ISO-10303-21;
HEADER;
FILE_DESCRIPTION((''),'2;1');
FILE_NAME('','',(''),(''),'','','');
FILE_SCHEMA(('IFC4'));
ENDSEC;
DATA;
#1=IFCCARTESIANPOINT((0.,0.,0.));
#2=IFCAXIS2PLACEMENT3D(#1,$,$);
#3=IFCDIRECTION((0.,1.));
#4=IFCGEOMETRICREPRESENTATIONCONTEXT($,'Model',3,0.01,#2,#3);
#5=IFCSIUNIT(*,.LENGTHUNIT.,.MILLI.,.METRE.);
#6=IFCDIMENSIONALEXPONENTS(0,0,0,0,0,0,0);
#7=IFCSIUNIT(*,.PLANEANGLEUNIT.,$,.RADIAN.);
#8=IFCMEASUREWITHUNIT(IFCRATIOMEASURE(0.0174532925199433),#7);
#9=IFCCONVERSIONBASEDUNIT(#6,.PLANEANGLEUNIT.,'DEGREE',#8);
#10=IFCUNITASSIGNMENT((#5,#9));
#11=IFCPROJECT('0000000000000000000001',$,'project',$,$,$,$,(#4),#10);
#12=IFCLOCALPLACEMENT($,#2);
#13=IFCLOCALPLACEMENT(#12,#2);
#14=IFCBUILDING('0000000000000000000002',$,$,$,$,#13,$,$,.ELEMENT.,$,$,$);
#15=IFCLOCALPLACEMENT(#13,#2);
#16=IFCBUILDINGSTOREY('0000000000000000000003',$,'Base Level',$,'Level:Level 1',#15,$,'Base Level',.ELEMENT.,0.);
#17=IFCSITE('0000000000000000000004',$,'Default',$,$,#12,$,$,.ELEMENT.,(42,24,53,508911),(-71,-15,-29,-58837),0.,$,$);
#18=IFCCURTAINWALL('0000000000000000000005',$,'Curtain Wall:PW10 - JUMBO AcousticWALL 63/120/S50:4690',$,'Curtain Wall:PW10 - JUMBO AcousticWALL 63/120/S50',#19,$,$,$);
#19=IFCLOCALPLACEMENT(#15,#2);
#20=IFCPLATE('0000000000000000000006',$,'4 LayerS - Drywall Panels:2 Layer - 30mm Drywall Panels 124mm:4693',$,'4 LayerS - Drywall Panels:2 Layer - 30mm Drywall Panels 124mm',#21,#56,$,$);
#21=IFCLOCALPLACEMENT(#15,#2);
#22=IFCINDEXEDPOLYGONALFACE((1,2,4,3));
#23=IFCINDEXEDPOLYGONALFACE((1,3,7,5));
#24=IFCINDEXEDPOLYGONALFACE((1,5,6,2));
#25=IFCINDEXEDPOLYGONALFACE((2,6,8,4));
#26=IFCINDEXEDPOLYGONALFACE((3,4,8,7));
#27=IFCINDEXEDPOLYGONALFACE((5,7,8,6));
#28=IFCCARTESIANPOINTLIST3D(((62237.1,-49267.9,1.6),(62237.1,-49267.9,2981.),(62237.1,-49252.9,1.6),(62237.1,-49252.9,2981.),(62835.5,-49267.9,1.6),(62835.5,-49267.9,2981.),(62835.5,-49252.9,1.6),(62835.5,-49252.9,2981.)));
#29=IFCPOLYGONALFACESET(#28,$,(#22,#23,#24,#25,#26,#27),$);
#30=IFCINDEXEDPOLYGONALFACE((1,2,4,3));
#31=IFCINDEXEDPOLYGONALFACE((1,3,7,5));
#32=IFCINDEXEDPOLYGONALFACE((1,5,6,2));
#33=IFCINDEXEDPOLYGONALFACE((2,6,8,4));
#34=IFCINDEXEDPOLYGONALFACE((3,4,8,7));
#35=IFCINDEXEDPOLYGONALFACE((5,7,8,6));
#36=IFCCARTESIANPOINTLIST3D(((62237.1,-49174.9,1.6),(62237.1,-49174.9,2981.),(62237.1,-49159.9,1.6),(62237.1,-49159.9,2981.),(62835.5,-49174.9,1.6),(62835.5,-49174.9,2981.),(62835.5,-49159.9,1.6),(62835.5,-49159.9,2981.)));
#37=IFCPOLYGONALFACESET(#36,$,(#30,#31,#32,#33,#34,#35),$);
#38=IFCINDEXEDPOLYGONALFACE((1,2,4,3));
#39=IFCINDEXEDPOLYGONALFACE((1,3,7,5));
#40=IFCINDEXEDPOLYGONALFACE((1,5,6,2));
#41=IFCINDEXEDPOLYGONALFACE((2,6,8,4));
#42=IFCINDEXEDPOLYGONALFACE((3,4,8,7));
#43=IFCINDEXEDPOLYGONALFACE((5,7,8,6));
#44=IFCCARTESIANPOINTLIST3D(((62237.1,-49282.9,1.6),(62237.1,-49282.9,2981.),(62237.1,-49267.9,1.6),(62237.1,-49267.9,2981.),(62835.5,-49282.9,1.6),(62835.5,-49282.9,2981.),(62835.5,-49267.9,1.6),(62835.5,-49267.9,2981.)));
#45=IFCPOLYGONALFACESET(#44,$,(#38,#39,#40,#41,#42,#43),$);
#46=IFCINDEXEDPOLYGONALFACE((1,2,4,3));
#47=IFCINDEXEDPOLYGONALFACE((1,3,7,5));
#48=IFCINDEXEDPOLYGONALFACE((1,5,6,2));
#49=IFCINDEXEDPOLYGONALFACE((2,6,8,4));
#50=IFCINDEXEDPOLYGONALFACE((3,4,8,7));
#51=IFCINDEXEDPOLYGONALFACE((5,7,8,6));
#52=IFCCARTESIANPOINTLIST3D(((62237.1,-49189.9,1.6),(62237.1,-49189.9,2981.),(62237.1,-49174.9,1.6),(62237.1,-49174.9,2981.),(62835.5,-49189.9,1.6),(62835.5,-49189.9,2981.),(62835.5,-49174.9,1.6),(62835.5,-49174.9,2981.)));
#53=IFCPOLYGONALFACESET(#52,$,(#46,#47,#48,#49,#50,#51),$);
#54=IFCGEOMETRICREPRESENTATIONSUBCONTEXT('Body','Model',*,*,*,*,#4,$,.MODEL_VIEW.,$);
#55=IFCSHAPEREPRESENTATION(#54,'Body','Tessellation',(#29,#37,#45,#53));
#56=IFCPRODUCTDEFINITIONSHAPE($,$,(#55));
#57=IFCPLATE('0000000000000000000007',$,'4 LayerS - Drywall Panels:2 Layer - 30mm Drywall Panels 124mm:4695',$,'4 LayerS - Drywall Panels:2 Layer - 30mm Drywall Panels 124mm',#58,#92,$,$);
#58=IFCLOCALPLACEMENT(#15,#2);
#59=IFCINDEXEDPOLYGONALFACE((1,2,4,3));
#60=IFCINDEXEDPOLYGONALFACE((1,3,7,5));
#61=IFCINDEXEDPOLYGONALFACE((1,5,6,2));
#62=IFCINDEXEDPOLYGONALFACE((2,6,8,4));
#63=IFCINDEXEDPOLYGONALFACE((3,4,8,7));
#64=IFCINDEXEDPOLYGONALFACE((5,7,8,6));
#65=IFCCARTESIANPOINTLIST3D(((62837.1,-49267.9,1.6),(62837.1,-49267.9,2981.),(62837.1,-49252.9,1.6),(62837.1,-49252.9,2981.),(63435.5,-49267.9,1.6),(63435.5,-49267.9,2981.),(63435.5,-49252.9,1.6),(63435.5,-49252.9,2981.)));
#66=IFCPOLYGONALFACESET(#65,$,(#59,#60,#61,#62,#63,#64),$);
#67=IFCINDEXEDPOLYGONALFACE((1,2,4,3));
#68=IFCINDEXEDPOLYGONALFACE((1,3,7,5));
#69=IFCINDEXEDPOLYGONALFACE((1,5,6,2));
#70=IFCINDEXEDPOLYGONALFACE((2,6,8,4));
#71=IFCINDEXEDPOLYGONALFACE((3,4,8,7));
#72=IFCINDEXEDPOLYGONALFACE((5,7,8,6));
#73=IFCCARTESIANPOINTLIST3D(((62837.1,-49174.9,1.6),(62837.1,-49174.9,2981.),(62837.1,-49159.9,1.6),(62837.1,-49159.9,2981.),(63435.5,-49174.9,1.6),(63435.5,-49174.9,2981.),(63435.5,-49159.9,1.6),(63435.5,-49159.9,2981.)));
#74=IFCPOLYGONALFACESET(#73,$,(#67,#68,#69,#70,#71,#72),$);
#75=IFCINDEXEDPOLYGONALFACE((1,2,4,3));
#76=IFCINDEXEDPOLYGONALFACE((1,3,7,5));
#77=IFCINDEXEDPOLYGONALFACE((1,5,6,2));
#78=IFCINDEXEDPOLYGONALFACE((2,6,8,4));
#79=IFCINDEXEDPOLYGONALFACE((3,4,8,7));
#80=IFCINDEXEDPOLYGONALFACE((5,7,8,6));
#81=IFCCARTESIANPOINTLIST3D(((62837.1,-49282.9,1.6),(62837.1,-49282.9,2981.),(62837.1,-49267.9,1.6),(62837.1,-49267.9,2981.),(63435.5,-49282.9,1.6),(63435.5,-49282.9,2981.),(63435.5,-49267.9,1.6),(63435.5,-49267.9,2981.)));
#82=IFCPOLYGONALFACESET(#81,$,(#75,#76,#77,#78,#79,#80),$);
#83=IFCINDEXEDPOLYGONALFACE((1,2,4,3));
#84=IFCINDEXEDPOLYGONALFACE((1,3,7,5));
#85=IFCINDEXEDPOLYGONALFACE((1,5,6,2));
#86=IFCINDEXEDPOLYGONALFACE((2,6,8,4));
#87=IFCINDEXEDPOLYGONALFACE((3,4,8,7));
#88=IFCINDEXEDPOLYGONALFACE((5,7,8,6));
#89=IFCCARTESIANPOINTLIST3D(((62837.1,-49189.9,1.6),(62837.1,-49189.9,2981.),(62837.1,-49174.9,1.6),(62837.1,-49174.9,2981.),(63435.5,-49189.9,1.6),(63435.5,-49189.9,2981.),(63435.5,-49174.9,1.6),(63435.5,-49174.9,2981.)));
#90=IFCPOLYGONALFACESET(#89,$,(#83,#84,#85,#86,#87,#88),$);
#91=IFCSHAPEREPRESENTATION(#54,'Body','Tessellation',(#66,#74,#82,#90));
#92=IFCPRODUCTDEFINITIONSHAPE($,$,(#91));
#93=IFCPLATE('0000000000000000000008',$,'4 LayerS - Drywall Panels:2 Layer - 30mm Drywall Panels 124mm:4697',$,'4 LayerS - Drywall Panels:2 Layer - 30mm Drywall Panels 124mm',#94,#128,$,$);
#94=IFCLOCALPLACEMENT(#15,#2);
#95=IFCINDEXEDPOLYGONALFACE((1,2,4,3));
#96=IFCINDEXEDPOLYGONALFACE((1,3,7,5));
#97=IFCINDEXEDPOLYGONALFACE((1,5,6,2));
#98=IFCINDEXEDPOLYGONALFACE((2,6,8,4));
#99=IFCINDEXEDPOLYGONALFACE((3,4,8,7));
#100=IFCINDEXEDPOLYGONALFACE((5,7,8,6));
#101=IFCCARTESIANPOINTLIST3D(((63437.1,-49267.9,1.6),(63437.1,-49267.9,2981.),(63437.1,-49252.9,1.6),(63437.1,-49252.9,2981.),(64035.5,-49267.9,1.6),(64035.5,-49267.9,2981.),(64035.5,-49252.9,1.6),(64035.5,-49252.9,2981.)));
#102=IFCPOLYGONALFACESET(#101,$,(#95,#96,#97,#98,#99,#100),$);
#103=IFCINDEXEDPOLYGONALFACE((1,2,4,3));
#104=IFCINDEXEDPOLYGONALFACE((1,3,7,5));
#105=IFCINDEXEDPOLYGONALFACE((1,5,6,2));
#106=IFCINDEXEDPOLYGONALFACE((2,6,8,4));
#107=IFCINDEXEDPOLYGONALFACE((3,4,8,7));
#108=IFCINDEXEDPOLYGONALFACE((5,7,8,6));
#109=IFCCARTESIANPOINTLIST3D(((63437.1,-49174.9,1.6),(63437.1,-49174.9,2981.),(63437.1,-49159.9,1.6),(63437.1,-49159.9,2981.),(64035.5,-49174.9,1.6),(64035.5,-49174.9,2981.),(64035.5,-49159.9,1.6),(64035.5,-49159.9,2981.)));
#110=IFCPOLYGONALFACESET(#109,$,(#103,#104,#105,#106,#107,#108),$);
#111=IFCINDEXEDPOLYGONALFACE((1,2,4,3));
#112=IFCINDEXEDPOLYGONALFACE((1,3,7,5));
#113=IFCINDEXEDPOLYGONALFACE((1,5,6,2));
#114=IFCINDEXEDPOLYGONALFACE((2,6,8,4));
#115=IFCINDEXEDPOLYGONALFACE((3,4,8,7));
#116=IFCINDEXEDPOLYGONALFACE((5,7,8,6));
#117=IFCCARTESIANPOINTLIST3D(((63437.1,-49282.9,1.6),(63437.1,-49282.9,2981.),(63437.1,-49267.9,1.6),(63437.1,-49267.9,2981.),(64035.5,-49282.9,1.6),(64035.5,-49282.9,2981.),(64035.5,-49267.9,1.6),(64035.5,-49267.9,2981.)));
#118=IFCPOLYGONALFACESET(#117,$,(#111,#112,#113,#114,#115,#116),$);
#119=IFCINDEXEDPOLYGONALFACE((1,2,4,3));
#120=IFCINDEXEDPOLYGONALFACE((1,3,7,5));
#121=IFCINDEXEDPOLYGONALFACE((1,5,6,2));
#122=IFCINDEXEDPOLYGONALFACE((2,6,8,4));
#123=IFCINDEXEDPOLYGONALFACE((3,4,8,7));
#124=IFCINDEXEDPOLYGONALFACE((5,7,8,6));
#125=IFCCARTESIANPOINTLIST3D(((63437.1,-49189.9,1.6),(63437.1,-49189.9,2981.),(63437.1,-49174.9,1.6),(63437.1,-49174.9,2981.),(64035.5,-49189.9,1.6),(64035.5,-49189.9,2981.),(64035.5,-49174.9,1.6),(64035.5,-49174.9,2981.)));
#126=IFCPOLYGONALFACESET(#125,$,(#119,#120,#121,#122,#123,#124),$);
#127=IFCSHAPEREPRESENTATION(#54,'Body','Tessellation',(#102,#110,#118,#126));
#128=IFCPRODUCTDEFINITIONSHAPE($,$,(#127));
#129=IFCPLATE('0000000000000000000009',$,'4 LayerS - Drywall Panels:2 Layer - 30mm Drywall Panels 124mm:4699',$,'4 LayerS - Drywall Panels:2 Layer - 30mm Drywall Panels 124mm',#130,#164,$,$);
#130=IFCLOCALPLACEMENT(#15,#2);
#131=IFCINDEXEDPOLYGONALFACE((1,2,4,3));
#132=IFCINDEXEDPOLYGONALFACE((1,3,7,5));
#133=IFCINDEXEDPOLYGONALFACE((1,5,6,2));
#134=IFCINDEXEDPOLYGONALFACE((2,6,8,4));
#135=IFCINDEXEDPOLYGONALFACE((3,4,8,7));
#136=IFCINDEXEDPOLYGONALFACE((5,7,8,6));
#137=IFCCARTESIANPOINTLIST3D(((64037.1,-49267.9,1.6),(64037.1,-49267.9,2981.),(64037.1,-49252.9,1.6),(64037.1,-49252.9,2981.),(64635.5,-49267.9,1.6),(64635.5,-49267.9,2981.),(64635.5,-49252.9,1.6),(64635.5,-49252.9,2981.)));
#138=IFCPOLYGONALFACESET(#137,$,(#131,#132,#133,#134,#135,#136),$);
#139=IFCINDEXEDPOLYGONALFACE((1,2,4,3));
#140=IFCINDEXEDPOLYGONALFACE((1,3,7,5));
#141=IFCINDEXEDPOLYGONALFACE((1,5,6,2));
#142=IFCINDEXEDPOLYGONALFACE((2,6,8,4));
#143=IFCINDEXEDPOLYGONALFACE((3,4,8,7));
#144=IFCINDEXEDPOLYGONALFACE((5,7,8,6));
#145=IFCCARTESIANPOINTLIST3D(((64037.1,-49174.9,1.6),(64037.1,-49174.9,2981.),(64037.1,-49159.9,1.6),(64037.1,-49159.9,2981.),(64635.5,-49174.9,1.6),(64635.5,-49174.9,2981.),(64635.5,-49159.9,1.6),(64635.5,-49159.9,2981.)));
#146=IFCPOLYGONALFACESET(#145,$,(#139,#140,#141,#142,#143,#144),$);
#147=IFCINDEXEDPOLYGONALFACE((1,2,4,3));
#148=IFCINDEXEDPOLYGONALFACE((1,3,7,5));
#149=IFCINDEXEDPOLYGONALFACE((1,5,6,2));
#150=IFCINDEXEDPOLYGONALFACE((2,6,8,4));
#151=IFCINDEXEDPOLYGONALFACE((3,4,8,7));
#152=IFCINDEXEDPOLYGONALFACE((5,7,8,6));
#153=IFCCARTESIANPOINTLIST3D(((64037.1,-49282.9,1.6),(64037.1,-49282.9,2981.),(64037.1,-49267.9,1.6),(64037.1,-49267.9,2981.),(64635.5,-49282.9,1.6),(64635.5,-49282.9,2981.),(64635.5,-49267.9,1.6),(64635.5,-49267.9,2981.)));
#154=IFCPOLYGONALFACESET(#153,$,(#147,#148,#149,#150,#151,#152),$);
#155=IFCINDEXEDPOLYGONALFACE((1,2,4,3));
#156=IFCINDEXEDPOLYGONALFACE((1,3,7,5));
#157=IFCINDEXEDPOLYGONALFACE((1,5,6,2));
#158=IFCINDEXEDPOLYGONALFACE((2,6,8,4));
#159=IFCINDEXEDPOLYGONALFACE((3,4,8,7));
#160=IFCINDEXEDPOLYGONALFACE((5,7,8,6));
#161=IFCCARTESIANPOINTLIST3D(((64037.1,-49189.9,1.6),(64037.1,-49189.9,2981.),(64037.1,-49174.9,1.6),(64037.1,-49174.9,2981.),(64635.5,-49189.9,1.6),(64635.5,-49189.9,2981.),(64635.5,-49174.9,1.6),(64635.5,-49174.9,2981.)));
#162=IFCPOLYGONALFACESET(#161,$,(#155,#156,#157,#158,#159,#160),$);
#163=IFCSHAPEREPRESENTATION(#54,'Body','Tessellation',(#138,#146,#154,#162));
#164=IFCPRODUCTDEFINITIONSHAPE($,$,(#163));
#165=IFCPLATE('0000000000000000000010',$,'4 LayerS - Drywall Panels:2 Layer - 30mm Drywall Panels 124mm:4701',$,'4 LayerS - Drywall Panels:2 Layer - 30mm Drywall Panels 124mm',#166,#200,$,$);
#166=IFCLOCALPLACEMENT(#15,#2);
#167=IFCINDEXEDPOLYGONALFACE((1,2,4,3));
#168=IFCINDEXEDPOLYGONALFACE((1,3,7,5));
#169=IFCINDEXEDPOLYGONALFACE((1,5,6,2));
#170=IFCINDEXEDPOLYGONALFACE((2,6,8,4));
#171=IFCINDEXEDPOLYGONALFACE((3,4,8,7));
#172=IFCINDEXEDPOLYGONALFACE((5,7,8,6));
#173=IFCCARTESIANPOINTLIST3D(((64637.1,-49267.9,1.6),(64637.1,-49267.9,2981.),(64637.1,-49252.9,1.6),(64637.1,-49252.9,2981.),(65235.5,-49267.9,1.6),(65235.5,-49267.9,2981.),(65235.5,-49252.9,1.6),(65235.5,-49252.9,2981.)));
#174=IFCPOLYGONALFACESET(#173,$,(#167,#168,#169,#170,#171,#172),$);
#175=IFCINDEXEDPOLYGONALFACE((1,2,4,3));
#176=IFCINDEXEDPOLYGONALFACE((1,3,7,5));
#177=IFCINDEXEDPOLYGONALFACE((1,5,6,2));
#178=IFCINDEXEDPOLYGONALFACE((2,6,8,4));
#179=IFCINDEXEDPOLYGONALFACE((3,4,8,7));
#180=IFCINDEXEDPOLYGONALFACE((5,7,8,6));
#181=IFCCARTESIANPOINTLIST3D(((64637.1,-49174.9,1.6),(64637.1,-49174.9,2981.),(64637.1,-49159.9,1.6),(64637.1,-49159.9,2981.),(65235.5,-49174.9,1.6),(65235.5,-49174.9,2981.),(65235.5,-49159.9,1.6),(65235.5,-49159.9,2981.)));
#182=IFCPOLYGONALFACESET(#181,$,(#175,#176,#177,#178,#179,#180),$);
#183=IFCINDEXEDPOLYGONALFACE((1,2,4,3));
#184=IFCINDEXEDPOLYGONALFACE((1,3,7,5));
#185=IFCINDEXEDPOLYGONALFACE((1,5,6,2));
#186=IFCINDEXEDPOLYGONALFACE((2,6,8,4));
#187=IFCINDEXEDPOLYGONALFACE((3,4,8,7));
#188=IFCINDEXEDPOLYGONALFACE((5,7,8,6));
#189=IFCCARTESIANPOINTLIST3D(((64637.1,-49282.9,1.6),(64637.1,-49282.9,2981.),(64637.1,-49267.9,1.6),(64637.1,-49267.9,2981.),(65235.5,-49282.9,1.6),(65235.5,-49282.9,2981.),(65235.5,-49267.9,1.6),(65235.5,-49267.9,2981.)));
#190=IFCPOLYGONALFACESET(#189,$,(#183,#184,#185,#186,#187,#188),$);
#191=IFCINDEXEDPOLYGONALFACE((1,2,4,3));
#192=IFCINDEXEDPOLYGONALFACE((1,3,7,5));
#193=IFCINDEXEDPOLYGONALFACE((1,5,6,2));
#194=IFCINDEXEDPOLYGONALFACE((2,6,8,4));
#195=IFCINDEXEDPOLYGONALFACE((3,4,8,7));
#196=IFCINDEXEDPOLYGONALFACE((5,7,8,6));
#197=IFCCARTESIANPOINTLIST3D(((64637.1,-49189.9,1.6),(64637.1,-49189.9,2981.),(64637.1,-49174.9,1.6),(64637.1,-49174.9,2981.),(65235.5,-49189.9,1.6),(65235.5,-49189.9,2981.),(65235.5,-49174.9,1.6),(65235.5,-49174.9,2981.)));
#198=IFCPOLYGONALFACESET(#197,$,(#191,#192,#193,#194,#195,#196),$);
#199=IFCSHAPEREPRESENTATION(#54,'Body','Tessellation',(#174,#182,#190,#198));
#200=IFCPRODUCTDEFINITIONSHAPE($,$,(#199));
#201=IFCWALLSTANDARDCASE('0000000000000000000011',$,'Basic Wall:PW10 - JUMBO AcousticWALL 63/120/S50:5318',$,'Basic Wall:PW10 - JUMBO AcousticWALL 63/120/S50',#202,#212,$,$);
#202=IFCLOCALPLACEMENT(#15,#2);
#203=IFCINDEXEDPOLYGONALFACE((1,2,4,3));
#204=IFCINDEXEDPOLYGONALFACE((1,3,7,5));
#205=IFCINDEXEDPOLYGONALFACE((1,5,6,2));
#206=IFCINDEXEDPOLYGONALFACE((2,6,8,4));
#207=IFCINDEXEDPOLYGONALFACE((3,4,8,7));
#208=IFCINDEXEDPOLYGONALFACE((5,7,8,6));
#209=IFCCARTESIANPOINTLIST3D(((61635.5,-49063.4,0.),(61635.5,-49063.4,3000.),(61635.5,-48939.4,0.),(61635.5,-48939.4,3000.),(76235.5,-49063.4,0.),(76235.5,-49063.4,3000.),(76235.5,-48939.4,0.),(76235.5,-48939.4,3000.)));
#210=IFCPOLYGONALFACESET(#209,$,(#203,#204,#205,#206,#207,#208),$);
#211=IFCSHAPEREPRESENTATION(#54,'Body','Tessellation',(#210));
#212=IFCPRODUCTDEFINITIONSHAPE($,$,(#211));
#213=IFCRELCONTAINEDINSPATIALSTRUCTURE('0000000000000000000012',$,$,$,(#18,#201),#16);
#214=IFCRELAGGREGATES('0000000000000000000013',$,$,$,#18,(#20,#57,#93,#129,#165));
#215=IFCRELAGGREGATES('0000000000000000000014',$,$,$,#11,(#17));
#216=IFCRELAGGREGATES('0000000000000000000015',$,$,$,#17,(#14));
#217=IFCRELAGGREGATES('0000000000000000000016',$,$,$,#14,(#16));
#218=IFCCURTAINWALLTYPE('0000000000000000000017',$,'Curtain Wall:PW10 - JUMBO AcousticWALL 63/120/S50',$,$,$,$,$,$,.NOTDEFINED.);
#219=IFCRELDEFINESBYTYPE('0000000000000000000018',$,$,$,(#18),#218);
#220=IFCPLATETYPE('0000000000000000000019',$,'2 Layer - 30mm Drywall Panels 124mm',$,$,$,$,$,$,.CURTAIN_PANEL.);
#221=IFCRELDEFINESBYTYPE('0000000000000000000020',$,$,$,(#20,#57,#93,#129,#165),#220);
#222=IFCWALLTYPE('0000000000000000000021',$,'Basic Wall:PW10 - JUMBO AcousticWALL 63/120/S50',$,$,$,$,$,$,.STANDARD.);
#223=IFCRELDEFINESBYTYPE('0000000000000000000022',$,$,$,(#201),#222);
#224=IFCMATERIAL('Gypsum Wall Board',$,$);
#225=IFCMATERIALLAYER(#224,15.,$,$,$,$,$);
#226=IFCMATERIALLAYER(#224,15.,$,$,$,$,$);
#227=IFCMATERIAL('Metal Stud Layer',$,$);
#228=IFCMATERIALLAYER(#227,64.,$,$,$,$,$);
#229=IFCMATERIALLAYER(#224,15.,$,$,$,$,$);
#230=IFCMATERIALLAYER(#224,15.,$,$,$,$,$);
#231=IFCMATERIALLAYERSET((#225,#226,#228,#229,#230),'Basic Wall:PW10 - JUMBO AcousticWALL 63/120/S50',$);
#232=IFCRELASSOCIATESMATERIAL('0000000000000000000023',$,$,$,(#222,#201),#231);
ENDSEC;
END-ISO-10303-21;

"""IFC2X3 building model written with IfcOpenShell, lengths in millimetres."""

from ifc_helpers import new_model, entity, si_unit, converted_unit, direction, frame, frame_2d, origin, origin_2d_with_axis, place, context, subcontext, project, spatial, rectangle, extrude, source, transform, mapped, material, layer, layer_set, layer_usage, type_object, type_shapes, element, aggregate, save


model = new_model("IFC2X3")

# Units and contexts
model_context = context("Model", 3, precision=0.01, world=origin(), true_north=direction((0.0, 1.0)))
body_context = subcontext(model_context, "Body", "Model", "MODEL_VIEW")
ifc_project = project(units=[si_unit("LENGTHUNIT", "METRE", prefix="MILLI"), converted_unit("PLANEANGLEUNIT", "DEGREE", entity("IfcRatioMeasure", 0.0174532925199433), si_unit("PLANEANGLEUNIT", "RADIAN"), dimensions=[0, 0, 0, 0, 0, 0, 0])], contexts=[model_context])

# Site, building, storey
site_placement = place(None, origin())
site = spatial("IfcSite", under=ifc_project, at=site_placement, Name="Default", CompositionType="ELEMENT", RefLatitude=(42, 24, 53, 508911), RefLongitude=(-71, -15, -29, -58837), RefElevation=0.0)
building_placement = place(site_placement, origin())
building = spatial("IfcBuilding", under=site, at=building_placement, CompositionType="ELEMENT")
storey_placement = place(building_placement, origin())
storey = spatial("IfcBuildingStorey", under=building, at=storey_placement, Name="Base Level", ObjectType="Level:Level 1", LongName="Base Level", CompositionType="ELEMENT", Elevation=0.0)

# Curtain wall, plates
curtain_wall_type = type_object("IfcCurtainWallType", Name="Curtain Wall:PW10 - JUMBO AcousticWALL 63/120/S50", PredefinedType="NOTDEFINED")
curtain_wall_placement = place(building_placement, origin())
curtain_wall = element("IfcCurtainWall", 1, at=curtain_wall_placement, inside=storey, type_object=curtain_wall_type, Name="Curtain Wall:PW10 - JUMBO AcousticWALL 63/120/S50:4690", ObjectType="Curtain Wall:PW10 - JUMBO AcousticWALL 63/120/S50")
plate_type = type_object("IfcPlateType", Name="2 Layer - 30mm Drywall Panels 124mm", PredefinedType="CURTAIN_PANEL")
shared_shape_1 = source(origin(), body_context, "Body", "SweptSolid", [
    extrude(rectangle(XDim=15.0, YDim=598.4, at=origin_2d_with_axis()), frame((0.0, -39.0, 0.0), z_axis=(0.0, 0.0, 1.0), x_axis=(0.0, 1.0, 0.0)), (0.0, 0.0, 1.0), 2979.4),
    extrude(rectangle(XDim=15.0, YDim=598.4, at=origin_2d_with_axis()), frame((0.0, 54.0, 0.0), z_axis=(0.0, 0.0, 1.0), x_axis=(0.0, 1.0, 0.0)), (0.0, 0.0, 1.0), 2979.4),
    extrude(rectangle(XDim=598.4, YDim=15.0, at=frame_2d((0.0, 0.0), x_axis=(1.0, 0.0))), frame((0.0, -54.0, 0.0), z_axis=(0.0, 0.0, 1.0), x_axis=(-1.0, 0.0, 0.0)), (0.0, 0.0, 1.0), 2979.4),
    extrude(rectangle(XDim=15.0, YDim=598.4, at=frame_2d((0.0, 0.0), x_axis=(1.0, 0.0))), frame((0.0, 39.0, 0.0), z_axis=(0.0, 0.0, 1.0), x_axis=(0.0, 1.0, 0.0)), (0.0, 0.0, 1.0), 2979.4),
])
type_shapes(plate_type, [shared_shape_1])
plate_1_placement = place(curtain_wall_placement, frame((62536.3, -49221.4, 1.6)))
plate_1 = element("IfcPlate", 2, at=plate_1_placement, type_object=plate_type, Name="4 LayerS - Drywall Panels:2 Layer - 30mm Drywall Panels 124mm:4693", ObjectType="4 LayerS - Drywall Panels:2 Layer - 30mm Drywall Panels 124mm", context=body_context, shape_type="MappedRepresentation", body=[
    mapped(shared_shape_1, transform((0.0, 0.0, 0.0), scale=1.0)),
])
plate_2_placement = place(curtain_wall_placement, frame((63136.3, -49221.4, 1.6)))
plate_2 = element("IfcPlate", 3, at=plate_2_placement, type_object=plate_type, Name="4 LayerS - Drywall Panels:2 Layer - 30mm Drywall Panels 124mm:4695", ObjectType="4 LayerS - Drywall Panels:2 Layer - 30mm Drywall Panels 124mm", context=body_context, shape_type="MappedRepresentation", body=[
    mapped(shared_shape_1, transform((0.0, 0.0, 0.0), scale=1.0)),
])
plate_3_placement = place(curtain_wall_placement, frame((63736.3, -49221.4, 1.6)))
plate_3 = element("IfcPlate", 4, at=plate_3_placement, type_object=plate_type, Name="4 LayerS - Drywall Panels:2 Layer - 30mm Drywall Panels 124mm:4697", ObjectType="4 LayerS - Drywall Panels:2 Layer - 30mm Drywall Panels 124mm", context=body_context, shape_type="MappedRepresentation", body=[
    mapped(shared_shape_1, transform((0.0, 0.0, 0.0), scale=1.0)),
])
plate_4_placement = place(curtain_wall_placement, frame((64336.3, -49221.4, 1.6)))
plate_4 = element("IfcPlate", 5, at=plate_4_placement, type_object=plate_type, Name="4 LayerS - Drywall Panels:2 Layer - 30mm Drywall Panels 124mm:4699", ObjectType="4 LayerS - Drywall Panels:2 Layer - 30mm Drywall Panels 124mm", context=body_context, shape_type="MappedRepresentation", body=[
    mapped(shared_shape_1, transform((0.0, 0.0, 0.0), scale=1.0)),
])
plate_5_placement = place(curtain_wall_placement, frame((64936.3, -49221.4, 1.6)))
plate_5 = element("IfcPlate", 6, at=plate_5_placement, type_object=plate_type, Name="4 LayerS - Drywall Panels:2 Layer - 30mm Drywall Panels 124mm:4701", ObjectType="4 LayerS - Drywall Panels:2 Layer - 30mm Drywall Panels 124mm", context=body_context, shape_type="MappedRepresentation", body=[
    mapped(shared_shape_1, transform((0.0, 0.0, 0.0), scale=1.0)),
])
aggregate(curtain_wall, [plate_1, plate_2, plate_3, plate_4, plate_5])

# Wall
ifc_material_1 = material(Name="Gypsum Wall Board")
ifc_layer_1 = layer(ifc_material_1, 15.0)
ifc_layer_2 = layer(ifc_material_1, 15.0)
ifc_material_2 = material(Name="Metal Stud Layer")
ifc_layer_3 = layer(ifc_material_2, 64.0)
ifc_layer_4 = layer(ifc_material_1, 15.0)
ifc_layer_5 = layer(ifc_material_1, 15.0)
ifc_layer_set = layer_set([ifc_layer_1, ifc_layer_2, ifc_layer_3, ifc_layer_4, ifc_layer_5], Name="Basic Wall:PW10 - JUMBO AcousticWALL 63/120/S50")
ifc_layer_usage = layer_usage(ifc_layer_set, "AXIS2", "NEGATIVE", 62.0)
wall_type = type_object("IfcWallType", Name="Basic Wall:PW10 - JUMBO AcousticWALL 63/120/S50", PredefinedType="STANDARD", material=ifc_layer_set)
wall_placement = place(building_placement, frame((61635.5, -49001.4, 0.0)))
element("IfcWallStandardCase", 7, at=wall_placement, inside=storey, type_object=wall_type, material=ifc_layer_usage, Name="Basic Wall:PW10 - JUMBO AcousticWALL 63/120/S50:5318", ObjectType="Basic Wall:PW10 - JUMBO AcousticWALL 63/120/S50", context=body_context, shape_type="SweptSolid", body=[
    extrude(rectangle(XDim=14600.0, YDim=124.0, at=frame_2d((7300.0, 0.0), x_axis=(-1.0, 0.0))), origin(), (0.0, 0.0, 1.0), 3000.0),
])

save(model, "model.ifc")
